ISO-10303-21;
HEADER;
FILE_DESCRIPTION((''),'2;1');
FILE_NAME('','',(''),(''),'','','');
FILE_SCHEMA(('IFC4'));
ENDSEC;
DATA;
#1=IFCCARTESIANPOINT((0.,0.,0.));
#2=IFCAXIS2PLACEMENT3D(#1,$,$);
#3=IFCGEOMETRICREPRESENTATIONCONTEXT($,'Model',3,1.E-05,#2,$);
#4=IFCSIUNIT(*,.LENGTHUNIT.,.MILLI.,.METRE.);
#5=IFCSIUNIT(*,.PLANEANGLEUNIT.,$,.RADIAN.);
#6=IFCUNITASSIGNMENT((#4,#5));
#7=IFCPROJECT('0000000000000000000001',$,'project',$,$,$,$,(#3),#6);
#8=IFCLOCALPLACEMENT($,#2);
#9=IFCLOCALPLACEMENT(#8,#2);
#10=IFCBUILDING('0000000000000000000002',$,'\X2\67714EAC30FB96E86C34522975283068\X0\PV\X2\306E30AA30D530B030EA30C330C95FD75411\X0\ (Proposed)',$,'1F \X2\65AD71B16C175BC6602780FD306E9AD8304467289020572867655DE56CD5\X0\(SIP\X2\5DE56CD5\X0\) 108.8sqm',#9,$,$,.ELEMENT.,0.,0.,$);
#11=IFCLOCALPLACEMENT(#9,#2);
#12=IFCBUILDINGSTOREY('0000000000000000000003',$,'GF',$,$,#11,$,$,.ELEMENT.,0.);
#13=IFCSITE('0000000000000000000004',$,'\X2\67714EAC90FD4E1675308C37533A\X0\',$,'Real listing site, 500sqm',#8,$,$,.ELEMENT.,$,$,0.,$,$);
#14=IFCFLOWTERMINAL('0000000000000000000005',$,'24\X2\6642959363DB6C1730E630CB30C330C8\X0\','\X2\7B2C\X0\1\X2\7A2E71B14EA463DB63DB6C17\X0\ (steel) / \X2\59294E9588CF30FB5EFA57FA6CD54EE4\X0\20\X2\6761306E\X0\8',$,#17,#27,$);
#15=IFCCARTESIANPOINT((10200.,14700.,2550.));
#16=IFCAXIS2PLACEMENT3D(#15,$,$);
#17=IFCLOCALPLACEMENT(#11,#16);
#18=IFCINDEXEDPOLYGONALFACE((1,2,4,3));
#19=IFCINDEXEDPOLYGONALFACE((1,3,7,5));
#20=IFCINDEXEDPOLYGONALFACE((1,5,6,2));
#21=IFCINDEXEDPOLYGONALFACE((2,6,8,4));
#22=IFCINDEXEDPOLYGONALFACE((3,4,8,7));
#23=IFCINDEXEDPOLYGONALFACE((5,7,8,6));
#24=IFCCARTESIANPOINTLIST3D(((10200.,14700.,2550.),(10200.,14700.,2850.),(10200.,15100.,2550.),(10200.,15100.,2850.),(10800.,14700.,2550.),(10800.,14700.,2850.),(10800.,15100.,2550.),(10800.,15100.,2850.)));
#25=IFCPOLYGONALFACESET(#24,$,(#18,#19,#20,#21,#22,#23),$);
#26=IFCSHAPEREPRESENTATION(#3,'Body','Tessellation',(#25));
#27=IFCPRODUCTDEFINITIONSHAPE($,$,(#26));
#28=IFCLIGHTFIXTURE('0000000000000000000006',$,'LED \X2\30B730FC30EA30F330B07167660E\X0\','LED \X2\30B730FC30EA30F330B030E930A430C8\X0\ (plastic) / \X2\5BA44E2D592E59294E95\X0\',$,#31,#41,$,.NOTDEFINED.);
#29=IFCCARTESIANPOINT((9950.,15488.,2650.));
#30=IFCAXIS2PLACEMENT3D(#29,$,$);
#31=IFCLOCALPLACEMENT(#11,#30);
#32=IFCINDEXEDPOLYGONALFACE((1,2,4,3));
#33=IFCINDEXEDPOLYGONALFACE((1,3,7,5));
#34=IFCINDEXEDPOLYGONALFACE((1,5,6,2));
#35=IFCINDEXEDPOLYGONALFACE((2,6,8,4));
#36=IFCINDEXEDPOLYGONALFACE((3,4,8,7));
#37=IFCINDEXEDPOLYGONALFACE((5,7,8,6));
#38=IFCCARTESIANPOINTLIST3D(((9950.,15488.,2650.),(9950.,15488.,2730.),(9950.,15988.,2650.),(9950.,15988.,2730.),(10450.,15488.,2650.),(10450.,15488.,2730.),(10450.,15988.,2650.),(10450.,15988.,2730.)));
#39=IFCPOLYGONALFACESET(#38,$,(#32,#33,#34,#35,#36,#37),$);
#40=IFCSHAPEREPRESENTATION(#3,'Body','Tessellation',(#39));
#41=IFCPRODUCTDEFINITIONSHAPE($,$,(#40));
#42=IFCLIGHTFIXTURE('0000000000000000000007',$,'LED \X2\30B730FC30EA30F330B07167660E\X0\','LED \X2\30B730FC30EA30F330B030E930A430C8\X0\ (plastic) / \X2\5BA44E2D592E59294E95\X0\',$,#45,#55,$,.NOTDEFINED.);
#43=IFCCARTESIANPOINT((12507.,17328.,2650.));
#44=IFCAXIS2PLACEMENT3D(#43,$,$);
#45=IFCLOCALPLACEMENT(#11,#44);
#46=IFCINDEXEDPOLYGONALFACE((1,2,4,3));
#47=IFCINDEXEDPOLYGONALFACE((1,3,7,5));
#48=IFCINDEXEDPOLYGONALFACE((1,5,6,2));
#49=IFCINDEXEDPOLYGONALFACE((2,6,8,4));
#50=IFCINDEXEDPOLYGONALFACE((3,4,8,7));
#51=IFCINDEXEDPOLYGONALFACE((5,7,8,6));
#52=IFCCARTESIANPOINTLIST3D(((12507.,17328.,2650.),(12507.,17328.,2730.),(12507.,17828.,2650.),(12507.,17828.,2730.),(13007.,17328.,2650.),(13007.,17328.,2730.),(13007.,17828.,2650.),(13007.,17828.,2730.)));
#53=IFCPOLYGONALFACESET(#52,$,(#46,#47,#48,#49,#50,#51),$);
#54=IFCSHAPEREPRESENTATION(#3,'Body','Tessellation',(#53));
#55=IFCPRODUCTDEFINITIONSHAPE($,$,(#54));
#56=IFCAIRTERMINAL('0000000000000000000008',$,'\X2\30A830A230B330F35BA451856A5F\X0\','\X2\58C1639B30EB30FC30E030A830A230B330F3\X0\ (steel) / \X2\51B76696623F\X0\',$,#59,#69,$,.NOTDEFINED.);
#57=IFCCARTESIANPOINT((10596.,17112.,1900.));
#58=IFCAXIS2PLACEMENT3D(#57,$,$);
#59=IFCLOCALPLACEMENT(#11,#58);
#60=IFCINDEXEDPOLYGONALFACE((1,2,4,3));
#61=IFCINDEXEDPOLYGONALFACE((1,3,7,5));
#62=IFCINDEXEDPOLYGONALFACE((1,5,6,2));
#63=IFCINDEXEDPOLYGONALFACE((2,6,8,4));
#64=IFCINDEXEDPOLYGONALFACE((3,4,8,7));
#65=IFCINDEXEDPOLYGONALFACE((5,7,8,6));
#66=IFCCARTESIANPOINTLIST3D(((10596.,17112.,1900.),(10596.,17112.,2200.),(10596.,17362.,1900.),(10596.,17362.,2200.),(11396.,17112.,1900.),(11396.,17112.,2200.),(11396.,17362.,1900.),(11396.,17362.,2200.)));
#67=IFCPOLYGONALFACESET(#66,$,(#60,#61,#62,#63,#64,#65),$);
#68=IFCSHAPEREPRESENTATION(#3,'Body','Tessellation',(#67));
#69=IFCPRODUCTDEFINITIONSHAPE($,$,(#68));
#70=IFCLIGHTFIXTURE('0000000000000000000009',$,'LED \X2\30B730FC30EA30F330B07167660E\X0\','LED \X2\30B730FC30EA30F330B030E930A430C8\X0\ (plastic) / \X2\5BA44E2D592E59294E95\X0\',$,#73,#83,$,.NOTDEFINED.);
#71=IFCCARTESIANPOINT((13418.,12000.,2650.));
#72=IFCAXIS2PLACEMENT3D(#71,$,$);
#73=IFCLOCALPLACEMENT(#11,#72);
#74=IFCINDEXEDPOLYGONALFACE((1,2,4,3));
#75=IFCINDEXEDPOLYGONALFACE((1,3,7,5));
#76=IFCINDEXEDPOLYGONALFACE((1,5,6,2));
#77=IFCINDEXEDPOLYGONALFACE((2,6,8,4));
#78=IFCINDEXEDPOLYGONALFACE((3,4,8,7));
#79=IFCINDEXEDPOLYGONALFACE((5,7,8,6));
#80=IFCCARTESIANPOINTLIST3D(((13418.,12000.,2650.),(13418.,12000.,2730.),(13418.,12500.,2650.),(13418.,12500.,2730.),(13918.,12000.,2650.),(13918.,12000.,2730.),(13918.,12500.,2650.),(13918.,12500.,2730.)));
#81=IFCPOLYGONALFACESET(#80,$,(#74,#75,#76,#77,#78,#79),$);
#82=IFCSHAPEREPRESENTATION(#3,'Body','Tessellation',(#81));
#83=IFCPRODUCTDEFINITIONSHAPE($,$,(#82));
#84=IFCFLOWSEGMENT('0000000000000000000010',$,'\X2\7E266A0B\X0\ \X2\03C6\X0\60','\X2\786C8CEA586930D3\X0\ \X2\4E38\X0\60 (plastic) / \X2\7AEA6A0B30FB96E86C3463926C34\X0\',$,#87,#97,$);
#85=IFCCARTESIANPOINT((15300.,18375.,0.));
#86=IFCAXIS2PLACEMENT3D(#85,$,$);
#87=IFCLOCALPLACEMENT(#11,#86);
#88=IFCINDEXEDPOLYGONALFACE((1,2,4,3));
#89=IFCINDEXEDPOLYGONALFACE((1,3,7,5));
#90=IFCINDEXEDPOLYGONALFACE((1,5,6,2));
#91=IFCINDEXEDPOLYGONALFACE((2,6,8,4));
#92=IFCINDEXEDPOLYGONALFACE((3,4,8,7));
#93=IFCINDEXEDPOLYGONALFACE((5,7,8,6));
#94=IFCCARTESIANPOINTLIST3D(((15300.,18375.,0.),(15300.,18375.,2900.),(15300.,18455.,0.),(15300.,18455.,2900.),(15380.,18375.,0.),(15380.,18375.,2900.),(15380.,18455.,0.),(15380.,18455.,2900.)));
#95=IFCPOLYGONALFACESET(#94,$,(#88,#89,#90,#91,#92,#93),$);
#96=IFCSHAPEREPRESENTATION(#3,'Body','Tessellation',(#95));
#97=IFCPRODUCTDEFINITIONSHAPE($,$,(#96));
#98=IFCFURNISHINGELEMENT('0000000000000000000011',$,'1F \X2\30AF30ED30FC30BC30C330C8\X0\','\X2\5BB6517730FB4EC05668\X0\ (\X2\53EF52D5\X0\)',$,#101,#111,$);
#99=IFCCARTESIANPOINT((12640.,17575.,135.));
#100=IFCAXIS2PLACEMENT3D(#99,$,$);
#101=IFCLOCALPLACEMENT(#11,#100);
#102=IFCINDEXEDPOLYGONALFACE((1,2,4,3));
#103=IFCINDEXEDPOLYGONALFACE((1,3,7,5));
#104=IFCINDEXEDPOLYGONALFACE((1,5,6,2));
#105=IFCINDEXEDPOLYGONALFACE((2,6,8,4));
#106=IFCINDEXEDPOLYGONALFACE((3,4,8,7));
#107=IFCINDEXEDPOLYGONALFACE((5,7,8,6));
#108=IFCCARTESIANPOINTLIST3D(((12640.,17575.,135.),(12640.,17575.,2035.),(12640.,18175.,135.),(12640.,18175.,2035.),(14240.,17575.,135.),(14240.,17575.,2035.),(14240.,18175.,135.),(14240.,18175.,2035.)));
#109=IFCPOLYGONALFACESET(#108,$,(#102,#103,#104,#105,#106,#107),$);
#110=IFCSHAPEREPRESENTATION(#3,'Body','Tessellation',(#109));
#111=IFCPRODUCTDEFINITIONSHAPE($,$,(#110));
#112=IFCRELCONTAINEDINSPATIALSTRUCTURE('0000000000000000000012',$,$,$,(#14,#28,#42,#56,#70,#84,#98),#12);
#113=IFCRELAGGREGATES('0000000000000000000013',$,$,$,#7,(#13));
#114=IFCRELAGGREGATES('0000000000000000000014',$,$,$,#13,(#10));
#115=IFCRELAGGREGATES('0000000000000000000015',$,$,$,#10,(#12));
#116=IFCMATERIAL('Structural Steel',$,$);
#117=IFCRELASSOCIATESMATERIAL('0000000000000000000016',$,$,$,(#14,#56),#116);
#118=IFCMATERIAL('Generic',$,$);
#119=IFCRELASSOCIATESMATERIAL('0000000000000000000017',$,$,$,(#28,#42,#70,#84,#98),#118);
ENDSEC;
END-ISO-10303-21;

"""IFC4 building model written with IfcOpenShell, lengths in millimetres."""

from ifc_helpers import new_model, si_unit, frame, frame_2d, origin, place, context, project, spatial, rectangle, extrude, material, element, save


model = new_model("IFC4")

# Units and contexts
model_context = context("Model", 3, precision=1e-05, world=origin())
ifc_project = project(units=[si_unit("LENGTHUNIT", "METRE", prefix="MILLI"), si_unit("PLANEANGLEUNIT", "RADIAN")], contexts=[model_context])

# Site, building, storey
site_placement = place(None, origin())
site = spatial("IfcSite", under=ifc_project, at=site_placement, Name="東京都世田谷区", ObjectType="Real listing site, 500sqm", CompositionType="ELEMENT", RefElevation=0.0)
building_placement = place(site_placement, origin())
building = spatial("IfcBuilding", under=site, at=building_placement, Name="東京・雨水利用とPVのオフグリッド志向 (Proposed)", ObjectType="1F 断熱気密性能の高い木造在来工法(SIP工法) 108.8sqm", CompositionType="ELEMENT", ElevationOfRefHeight=0.0, ElevationOfTerrain=0.0)
storey_placement = place(building_placement, origin())
storey = spatial("IfcBuildingStorey", under=building, at=storey_placement, Name="GF", CompositionType="ELEMENT", Elevation=0.0)

# Shared definitions
ifc_material_1 = material(Name="Generic")

# Flow terminal
ifc_material_2 = material(Name="Structural Steel")
flow_terminal_placement = place(storey_placement, frame((10200.0, 14700.0, 2550.0)))
element("IfcFlowTerminal", 1, at=flow_terminal_placement, inside=storey, material=ifc_material_2, Name="24時間換気ユニット", Description="第1種熱交換換気 (steel) / 天井裏・建基法令20条の8", context=model_context, shape_type="SweptSolid", body=[
    extrude(rectangle(XDim=600.0, YDim=400.0, at=frame_2d((300.0, 200.0))), frame((10200.0, 14700.0, 2550.0)), (0.0, 0.0, 1.0), 300.0),
])

# Light fixtures
light_fixture_1_placement = place(storey_placement, frame((9950.0, 15488.0, 2650.0)))
element("IfcLightFixture", 2, at=light_fixture_1_placement, inside=storey, material=ifc_material_1, Name="LED シーリング照明", Description="LED シーリングライト (plastic) / 室中央天井", PredefinedType="NOTDEFINED", context=model_context, shape_type="SweptSolid", body=[
    extrude(rectangle(XDim=500.0, YDim=500.0, at=frame_2d((250.0, 250.0))), frame((9950.0, 15488.0, 2650.0)), (0.0, 0.0, 1.0), 80.0),
])
light_fixture_2_placement = place(storey_placement, frame((12507.0, 17328.0, 2650.0)))
element("IfcLightFixture", 3, at=light_fixture_2_placement, inside=storey, material=ifc_material_1, Name="LED シーリング照明", Description="LED シーリングライト (plastic) / 室中央天井", PredefinedType="NOTDEFINED", context=model_context, shape_type="SweptSolid", body=[
    extrude(rectangle(XDim=500.0, YDim=500.0, at=frame_2d((250.0, 250.0))), frame((12507.0, 17328.0, 2650.0)), (0.0, 0.0, 1.0), 80.0),
])

# Air terminal
air_terminal_placement = place(storey_placement, frame((10596.0, 17112.0, 1900.0)))
element("IfcAirTerminal", 4, at=air_terminal_placement, inside=storey, material=ifc_material_2, Name="エアコン室内機", Description="壁掛ルームエアコン (steel) / 冷暖房", PredefinedType="NOTDEFINED", context=model_context, shape_type="SweptSolid", body=[
    extrude(rectangle(XDim=800.0, YDim=250.0, at=frame_2d((400.0, 125.0))), frame((10596.0, 17112.0, 1900.0)), (0.0, 0.0, 1.0), 300.0),
])

# Light fixture
light_fixture_3_placement = place(storey_placement, frame((13418.0, 12000.0, 2650.0)))
element("IfcLightFixture", 5, at=light_fixture_3_placement, inside=storey, material=ifc_material_1, Name="LED シーリング照明", Description="LED シーリングライト (plastic) / 室中央天井", PredefinedType="NOTDEFINED", context=model_context, shape_type="SweptSolid", body=[
    extrude(rectangle(XDim=500.0, YDim=500.0, at=frame_2d((250.0, 250.0))), frame((13418.0, 12000.0, 2650.0)), (0.0, 0.0, 1.0), 80.0),
])

# Flow segment
flow_segment_placement = place(storey_placement, frame((15300.0, 18375.0, 0.0)))
element("IfcFlowSegment", 6, at=flow_segment_placement, inside=storey, material=ifc_material_1, Name="縦樋 φ60", Description="硬質塩ビ 丸60 (plastic) / 竪樋・雨水排水", context=model_context, shape_type="SweptSolid", body=[
    extrude(rectangle(XDim=80.0, YDim=80.0, at=frame_2d((40.0, 40.0))), frame((15300.0, 18375.0, 0.0)), (0.0, 0.0, 1.0), 2900.0),
])

# Furnishing element
furnishing_placement = place(storey_placement, frame((12640.0, 17575.0, 135.0)))
element("IfcFurnishingElement", 7, at=furnishing_placement, inside=storey, material=ifc_material_1, Name="1F クローゼット", Description="家具・什器 (可動)", context=model_context, shape_type="SweptSolid", body=[
    extrude(rectangle(XDim=1600.0, YDim=600.0, at=frame_2d((800.0, 300.0))), frame((12640.0, 17575.0, 135.0)), (0.0, 0.0, 1.0), 1900.0),
])

save(model, "model.ifc")
